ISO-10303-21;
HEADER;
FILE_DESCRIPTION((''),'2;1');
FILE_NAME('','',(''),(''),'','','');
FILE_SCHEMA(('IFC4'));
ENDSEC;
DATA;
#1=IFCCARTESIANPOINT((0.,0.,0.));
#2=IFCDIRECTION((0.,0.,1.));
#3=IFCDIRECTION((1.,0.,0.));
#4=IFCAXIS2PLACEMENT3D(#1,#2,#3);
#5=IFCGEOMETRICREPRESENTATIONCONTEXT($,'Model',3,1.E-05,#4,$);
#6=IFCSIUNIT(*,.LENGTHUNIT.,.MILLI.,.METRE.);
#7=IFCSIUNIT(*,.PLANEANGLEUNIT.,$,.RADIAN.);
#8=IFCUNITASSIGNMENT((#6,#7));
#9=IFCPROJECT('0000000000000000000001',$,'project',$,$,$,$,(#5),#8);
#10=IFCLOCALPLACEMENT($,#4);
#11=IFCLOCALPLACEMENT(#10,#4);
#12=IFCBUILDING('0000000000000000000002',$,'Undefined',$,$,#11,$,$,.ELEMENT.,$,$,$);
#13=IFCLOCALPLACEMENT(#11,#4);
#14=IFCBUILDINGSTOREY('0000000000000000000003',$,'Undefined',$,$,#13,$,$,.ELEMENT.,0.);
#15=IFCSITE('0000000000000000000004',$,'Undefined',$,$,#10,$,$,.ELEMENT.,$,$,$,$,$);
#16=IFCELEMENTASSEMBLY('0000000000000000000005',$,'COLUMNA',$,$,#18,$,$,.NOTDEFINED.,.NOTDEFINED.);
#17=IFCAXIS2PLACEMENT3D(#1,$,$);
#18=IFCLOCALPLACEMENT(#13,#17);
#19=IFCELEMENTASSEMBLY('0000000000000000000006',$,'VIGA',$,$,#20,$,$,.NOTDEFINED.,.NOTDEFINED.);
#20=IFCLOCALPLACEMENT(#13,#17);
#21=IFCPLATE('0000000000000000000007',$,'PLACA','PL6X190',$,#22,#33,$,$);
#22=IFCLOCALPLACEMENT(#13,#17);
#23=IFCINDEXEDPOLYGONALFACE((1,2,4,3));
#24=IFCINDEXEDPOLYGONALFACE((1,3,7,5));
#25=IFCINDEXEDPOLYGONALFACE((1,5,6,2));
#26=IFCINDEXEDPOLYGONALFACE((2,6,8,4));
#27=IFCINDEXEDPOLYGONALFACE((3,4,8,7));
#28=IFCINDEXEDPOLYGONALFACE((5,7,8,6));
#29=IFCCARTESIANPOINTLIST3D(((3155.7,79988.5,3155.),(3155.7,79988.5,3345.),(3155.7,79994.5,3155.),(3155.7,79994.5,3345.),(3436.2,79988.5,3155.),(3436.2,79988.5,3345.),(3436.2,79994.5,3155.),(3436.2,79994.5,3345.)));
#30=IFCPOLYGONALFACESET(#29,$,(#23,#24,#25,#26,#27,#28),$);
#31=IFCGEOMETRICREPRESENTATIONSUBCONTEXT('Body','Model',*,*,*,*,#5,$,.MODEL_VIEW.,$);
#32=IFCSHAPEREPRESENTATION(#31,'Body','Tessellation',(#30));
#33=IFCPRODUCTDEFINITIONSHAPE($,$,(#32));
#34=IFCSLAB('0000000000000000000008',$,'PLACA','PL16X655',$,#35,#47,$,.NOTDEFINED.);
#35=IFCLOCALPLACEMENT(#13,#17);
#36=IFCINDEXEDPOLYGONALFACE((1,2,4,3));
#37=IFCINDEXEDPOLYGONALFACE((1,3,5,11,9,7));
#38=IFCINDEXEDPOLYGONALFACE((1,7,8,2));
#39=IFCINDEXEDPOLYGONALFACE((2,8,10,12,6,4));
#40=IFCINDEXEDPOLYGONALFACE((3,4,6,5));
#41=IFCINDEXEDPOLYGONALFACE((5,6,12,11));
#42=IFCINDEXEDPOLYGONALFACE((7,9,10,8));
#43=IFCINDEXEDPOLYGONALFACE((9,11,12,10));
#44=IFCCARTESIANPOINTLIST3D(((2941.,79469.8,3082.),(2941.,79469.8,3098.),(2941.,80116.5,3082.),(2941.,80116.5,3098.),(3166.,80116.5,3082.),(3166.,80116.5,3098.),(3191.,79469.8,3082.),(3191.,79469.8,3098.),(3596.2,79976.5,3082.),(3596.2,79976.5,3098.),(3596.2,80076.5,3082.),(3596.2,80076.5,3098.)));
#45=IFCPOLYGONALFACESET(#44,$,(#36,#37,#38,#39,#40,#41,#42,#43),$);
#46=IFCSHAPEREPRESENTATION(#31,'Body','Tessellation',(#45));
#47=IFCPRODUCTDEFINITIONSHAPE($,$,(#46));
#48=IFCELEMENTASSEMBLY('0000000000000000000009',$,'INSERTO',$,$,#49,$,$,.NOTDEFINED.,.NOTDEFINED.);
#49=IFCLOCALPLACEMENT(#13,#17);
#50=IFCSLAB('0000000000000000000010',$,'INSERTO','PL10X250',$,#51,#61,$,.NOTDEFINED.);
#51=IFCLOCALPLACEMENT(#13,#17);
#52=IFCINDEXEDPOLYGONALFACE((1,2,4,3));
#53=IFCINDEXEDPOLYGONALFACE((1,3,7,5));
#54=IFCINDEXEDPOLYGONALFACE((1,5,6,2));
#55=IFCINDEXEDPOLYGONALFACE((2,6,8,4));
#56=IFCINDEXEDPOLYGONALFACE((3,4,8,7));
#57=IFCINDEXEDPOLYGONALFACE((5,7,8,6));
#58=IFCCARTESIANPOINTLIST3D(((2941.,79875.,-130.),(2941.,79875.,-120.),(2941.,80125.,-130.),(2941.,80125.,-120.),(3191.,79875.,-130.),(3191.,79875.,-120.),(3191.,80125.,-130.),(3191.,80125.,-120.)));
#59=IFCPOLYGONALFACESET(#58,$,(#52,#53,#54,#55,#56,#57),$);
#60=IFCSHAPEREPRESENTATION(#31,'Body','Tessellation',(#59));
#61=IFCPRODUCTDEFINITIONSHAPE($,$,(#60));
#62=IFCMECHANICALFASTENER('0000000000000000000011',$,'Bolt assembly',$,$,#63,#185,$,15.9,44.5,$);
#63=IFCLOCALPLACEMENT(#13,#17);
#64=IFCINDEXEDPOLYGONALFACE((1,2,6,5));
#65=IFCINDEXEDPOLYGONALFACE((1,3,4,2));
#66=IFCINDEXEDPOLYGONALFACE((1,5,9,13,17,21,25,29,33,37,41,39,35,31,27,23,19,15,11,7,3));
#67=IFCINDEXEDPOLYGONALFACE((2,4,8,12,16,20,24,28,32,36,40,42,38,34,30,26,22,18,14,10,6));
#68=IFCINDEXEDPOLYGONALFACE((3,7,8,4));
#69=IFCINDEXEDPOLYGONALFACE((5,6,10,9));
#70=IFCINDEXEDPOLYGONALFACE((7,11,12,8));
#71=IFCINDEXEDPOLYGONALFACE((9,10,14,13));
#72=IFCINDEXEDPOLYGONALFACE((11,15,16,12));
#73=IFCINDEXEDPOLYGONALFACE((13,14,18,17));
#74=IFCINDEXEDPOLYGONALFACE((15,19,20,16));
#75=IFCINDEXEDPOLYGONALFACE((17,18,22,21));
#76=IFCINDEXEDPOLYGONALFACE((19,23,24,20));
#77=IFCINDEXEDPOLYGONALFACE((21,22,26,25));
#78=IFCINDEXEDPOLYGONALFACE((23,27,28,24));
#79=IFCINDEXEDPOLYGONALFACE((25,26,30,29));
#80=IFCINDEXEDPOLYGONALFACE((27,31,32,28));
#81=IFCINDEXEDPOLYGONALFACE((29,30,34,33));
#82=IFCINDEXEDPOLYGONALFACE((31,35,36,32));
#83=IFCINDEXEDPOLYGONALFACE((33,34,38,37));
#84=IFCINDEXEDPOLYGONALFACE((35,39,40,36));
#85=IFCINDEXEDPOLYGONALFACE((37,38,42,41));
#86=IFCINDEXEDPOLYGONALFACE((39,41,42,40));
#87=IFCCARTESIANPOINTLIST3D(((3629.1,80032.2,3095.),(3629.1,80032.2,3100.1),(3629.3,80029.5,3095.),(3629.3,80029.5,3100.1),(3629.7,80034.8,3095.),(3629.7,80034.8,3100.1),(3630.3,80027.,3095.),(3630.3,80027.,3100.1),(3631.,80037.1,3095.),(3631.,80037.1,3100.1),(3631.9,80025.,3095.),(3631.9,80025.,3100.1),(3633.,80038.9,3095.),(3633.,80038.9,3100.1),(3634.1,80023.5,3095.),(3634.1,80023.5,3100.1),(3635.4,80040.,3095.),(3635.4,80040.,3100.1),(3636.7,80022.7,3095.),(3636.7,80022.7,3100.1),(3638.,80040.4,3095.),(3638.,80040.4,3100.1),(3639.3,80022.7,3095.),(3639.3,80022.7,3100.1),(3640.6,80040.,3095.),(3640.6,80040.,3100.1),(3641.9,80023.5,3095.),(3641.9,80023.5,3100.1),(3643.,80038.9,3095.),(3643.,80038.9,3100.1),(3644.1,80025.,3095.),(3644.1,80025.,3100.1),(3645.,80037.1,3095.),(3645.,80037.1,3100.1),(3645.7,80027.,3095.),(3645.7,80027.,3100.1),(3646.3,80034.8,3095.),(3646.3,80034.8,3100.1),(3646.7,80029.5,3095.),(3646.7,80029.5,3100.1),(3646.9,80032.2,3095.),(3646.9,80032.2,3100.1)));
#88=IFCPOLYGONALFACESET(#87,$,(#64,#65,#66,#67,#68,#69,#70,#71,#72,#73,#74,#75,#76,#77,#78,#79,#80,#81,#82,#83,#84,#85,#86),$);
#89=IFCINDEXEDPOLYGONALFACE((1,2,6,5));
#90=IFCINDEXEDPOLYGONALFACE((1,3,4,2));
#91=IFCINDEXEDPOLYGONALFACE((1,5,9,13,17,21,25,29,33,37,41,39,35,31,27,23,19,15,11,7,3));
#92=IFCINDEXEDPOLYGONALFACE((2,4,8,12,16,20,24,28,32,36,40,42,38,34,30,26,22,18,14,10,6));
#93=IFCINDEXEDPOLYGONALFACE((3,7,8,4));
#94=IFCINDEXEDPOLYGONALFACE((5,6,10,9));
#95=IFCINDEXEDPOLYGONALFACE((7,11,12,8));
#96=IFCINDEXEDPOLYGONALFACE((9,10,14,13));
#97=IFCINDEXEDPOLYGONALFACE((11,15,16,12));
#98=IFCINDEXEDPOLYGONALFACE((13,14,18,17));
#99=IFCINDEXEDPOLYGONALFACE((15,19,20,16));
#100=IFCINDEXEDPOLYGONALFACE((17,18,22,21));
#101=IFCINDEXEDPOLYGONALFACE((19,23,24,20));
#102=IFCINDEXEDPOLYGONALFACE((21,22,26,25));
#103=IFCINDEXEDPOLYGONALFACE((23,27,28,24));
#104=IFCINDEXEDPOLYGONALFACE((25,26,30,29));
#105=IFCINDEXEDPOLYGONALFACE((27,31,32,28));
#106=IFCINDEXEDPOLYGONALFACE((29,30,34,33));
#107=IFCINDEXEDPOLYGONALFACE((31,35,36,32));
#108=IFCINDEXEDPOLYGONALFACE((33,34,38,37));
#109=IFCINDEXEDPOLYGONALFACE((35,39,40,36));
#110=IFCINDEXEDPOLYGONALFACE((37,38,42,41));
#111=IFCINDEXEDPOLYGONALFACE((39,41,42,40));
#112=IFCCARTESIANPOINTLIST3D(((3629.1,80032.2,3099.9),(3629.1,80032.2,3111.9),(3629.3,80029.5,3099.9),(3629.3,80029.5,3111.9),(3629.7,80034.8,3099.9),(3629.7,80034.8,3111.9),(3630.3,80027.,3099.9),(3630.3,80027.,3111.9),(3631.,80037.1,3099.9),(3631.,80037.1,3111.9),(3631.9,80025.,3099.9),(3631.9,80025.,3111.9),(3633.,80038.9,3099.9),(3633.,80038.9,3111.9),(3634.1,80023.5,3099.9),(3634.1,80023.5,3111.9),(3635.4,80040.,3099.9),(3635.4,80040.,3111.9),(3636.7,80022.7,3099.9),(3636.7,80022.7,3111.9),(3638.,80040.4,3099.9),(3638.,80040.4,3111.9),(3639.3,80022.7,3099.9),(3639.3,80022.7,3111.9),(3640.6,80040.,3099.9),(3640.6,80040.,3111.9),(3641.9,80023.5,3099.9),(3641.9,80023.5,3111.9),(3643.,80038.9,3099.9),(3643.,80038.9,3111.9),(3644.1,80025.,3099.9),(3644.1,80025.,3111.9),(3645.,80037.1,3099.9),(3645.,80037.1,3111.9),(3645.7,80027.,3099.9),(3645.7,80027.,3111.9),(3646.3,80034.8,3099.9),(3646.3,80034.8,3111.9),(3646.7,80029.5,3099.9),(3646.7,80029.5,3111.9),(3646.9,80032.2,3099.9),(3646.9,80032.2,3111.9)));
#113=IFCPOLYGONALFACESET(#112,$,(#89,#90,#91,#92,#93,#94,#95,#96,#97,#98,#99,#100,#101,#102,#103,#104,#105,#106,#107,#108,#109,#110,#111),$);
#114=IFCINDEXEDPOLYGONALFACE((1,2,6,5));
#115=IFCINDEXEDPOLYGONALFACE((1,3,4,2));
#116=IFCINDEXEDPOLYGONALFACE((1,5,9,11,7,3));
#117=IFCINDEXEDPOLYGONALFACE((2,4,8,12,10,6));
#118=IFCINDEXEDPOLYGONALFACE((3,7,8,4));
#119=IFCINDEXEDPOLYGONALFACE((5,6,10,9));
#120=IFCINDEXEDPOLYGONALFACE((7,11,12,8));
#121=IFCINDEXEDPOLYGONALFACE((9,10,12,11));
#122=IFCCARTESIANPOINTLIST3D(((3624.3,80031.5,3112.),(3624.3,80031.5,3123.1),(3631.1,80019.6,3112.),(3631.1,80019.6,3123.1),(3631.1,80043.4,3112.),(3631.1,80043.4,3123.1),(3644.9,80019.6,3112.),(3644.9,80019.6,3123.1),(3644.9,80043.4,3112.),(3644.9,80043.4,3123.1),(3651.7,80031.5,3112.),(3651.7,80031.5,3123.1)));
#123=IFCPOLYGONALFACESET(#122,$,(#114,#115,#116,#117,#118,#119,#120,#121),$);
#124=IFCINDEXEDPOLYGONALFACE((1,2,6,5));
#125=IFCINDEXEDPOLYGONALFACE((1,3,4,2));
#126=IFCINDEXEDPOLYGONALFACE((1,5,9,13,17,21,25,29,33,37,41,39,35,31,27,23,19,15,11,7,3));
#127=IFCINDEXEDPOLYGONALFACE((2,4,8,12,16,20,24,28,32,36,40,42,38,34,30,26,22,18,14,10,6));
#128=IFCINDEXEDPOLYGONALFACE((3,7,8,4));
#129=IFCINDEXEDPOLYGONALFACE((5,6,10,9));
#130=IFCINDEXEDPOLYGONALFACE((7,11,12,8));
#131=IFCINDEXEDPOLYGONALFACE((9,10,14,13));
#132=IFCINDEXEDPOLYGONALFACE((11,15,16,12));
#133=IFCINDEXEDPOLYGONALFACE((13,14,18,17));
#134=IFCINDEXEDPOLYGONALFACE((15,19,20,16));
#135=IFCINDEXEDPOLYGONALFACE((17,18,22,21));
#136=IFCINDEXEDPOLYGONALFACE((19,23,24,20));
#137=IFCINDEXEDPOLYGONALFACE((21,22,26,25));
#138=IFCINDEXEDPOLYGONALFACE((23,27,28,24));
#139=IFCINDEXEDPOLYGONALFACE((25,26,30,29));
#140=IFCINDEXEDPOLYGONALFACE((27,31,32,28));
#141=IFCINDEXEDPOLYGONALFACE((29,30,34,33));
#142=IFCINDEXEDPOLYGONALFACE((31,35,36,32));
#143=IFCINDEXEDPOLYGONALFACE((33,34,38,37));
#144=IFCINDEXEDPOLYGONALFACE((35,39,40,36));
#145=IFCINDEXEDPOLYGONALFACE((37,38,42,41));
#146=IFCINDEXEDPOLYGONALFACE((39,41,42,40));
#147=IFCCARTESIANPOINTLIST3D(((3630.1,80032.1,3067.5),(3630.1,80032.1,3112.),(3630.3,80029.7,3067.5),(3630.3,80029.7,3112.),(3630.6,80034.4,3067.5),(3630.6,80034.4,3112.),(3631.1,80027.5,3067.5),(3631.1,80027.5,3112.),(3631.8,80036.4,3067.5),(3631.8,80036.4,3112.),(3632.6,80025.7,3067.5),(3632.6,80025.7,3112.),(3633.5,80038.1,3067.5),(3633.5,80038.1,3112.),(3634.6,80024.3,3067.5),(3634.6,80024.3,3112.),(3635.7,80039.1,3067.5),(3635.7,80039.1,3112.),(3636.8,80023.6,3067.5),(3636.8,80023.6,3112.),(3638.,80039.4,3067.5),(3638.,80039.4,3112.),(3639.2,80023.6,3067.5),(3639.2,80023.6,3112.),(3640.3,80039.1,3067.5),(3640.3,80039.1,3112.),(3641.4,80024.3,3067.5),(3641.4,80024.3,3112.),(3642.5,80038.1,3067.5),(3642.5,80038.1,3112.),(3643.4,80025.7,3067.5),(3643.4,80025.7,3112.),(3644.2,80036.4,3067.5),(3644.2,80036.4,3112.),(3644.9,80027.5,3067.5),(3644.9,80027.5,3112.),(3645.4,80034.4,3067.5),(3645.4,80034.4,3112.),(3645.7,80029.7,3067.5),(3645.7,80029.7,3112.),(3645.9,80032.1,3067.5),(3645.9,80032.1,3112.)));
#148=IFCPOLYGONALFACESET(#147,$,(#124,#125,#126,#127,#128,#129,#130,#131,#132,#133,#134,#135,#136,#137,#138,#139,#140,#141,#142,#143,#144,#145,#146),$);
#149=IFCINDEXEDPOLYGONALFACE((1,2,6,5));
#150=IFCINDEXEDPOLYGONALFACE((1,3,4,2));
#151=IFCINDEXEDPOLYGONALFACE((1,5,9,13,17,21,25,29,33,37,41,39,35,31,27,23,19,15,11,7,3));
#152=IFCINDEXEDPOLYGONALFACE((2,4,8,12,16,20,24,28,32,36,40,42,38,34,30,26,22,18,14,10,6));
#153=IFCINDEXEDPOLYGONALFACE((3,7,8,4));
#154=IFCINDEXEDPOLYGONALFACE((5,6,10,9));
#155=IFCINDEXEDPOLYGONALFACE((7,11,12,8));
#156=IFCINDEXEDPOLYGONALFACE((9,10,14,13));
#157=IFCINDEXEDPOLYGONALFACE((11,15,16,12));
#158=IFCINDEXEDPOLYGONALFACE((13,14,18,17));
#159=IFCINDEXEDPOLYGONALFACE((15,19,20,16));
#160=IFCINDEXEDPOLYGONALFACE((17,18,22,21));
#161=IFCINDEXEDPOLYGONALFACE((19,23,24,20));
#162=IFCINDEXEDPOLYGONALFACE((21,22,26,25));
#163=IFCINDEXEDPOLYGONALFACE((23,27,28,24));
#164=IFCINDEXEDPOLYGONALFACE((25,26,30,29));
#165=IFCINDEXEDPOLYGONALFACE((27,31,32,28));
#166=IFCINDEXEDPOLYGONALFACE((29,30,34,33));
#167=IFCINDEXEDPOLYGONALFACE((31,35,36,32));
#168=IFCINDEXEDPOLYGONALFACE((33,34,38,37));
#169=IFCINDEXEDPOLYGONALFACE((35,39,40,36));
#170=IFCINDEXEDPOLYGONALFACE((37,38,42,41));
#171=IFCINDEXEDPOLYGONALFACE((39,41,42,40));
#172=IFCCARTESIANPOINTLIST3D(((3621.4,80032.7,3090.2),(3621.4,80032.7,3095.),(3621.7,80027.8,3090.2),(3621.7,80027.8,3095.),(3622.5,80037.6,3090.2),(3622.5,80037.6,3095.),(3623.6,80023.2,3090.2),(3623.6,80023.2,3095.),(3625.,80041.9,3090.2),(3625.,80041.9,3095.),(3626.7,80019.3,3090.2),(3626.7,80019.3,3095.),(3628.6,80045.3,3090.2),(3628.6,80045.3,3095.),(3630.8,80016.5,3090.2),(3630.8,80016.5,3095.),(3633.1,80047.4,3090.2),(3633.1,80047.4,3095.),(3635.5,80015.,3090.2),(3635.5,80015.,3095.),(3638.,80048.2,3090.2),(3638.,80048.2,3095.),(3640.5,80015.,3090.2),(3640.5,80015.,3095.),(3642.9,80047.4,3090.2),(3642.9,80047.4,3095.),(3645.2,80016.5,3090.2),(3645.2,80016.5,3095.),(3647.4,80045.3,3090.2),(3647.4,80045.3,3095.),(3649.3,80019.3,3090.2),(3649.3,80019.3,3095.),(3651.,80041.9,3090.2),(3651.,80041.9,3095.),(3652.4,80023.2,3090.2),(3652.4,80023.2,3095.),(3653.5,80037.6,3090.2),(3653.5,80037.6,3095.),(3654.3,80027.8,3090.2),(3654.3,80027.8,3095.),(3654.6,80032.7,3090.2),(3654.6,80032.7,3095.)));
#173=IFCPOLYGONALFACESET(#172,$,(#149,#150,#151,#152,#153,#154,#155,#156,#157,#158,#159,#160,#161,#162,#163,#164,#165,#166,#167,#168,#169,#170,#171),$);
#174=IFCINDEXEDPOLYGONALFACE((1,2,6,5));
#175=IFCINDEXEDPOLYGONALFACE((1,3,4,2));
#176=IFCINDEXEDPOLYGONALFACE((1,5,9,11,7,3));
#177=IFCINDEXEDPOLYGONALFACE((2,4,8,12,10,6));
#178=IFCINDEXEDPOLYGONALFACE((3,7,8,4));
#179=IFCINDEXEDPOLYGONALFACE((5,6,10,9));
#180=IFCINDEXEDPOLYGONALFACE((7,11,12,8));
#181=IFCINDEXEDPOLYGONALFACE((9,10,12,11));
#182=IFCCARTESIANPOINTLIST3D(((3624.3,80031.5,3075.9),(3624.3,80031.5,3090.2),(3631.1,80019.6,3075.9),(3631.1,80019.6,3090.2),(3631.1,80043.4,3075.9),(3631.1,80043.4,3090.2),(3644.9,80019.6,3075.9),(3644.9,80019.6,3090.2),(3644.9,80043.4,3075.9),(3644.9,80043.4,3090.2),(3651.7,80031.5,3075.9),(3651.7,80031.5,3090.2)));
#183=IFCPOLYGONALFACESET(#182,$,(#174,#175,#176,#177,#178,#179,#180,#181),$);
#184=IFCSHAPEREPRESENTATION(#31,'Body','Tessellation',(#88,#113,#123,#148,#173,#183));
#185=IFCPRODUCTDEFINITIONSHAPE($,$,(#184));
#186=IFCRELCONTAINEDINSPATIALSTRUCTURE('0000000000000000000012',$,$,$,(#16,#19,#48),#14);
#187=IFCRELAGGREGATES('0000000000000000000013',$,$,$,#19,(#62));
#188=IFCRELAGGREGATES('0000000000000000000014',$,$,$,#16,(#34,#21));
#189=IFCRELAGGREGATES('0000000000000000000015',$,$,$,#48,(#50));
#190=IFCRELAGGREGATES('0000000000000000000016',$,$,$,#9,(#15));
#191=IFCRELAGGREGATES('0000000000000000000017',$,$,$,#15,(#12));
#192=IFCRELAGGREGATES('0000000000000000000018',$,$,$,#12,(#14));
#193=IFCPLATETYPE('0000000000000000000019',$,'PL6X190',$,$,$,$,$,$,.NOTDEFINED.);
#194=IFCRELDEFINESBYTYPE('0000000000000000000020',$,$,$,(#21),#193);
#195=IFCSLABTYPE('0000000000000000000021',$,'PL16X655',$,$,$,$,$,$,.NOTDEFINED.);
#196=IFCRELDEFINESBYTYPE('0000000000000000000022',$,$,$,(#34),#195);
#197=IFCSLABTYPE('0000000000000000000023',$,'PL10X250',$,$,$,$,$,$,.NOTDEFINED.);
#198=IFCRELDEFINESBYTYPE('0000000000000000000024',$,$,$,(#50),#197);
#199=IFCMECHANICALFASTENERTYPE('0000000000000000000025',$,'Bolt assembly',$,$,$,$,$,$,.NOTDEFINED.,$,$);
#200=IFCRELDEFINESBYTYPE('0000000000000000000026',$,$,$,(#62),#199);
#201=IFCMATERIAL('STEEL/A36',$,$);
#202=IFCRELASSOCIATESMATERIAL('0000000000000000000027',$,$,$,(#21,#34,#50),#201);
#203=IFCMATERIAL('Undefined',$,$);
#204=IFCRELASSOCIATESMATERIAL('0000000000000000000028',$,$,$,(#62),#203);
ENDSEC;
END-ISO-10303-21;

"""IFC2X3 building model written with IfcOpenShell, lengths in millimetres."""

from ifc_helpers import new_model, si_unit, frame, origin_with_axes, origin_2d_with_axis, place, context, subcontext, project, spatial, polyline, circle, outline, extrude, source, transform, mapped, material, type_object, element, aggregate, save


model = new_model("IFC2X3")

# Units and contexts
model_context = context("Model", 3, precision=1e-05, world=origin_with_axes())
body_context = subcontext(model_context, "Body", "Model", "MODEL_VIEW")
ifc_project = project(units=[si_unit("LENGTHUNIT", "METRE", prefix="MILLI"), si_unit("PLANEANGLEUNIT", "RADIAN")], contexts=[model_context])

# Site, building, storey
site_placement = place(None, origin_with_axes())
site = spatial("IfcSite", under=ifc_project, at=site_placement, Name="Undefined", CompositionType="ELEMENT")
building_placement = place(site_placement, origin_with_axes())
building = spatial("IfcBuilding", under=site, at=building_placement, Name="Undefined", CompositionType="ELEMENT")
storey_placement = place(building_placement, origin_with_axes())
storey = spatial("IfcBuildingStorey", under=building, at=storey_placement, Name="Undefined", CompositionType="ELEMENT", Elevation=0.0)

# Element assembly
assembly_1_placement = place(storey_placement, origin_with_axes())
assembly_1 = element("IfcElementAssembly", 1, at=assembly_1_placement, inside=storey, Name="COLUMNA", AssemblyPlace="NOTDEFINED", PredefinedType="NOTDEFINED")
ifc_material_1 = material(Name="STEEL/A36")

# Element assembly
assembly_2_placement = place(storey_placement, origin_with_axes())
assembly_2 = element("IfcElementAssembly", 2, at=assembly_2_placement, inside=storey, Name="VIGA", AssemblyPlace="NOTDEFINED", PredefinedType="NOTDEFINED")

# Plate
plate_type_1 = type_object("IfcPlateType", Name="PL6X190", PredefinedType="NOTDEFINED")
plate_1_placement = place(assembly_1_placement, frame((3436.2, 79991.5, 3250.0), z_axis=(0.0, 1.0, 0.0), x_axis=(-1.0, 0.0, 0.0)))
plate_1 = element("IfcPlate", 3, at=plate_1_placement, type_object=plate_type_1, material=ifc_material_1, Name="PLACA", Description="PL6X190", context=body_context, shape_type="SweptSolid", body=[
    extrude(outline(polyline([(0.0, -95.0), (0.0, 95.0), (280.5, 95.0), (280.5, -95.0), (0.0, -95.0)])), frame((0.0, 0.0, -3.0), z_axis=(0.0, 0.0, 1.0), x_axis=(1.0, 0.0, 0.0)), (0.0, 0.0, 1.0), 6.0),
])

# Slab
slab_type_1 = type_object("IfcSlabType", Name="PL16X655", PredefinedType="NOTDEFINED")
slab_1_placement = place(assembly_1_placement, frame((3191.0, 79469.8, 3090.0), z_axis=(0.0, 0.0, 1.0), x_axis=(0.624549, 0.780985, 0.0)))
slab_1 = element("IfcSlab", 4, at=slab_1_placement, type_object=slab_type_1, material=ifc_material_1, Name="PLACA", Description="PL16X655", PredefinedType="NOTDEFINED", context=body_context, shape_type="SweptSolid", body=[
    extrude(outline(polyline([(0.0, 0.0), (648.8, 0.0), (726.9, 62.5), (489.5, 423.4), (348.9, 599.2), (-156.1, 195.2), (0.0, 0.0)])), frame((0.0, 0.0, -8.0), z_axis=(0.0, 0.0, 1.0), x_axis=(1.0, 0.0, 0.0)), (0.0, 0.0, 1.0), 16.0),
])

# Element assembly, slab
assembly_3_placement = place(storey_placement, origin_with_axes())
assembly_3 = element("IfcElementAssembly", 5, at=assembly_3_placement, inside=storey, Name="INSERTO", AssemblyPlace="NOTDEFINED", PredefinedType="NOTDEFINED")
slab_type_2 = type_object("IfcSlabType", Name="PL10X250", PredefinedType="NOTDEFINED")
slab_2_placement = place(assembly_3_placement, frame((2941.0, 79875.0, -125.0), z_axis=(0.0, 0.0, 1.0), x_axis=(1.0, 0.0, 0.0)))
slab_2 = element("IfcSlab", 6, at=slab_2_placement, type_object=slab_type_2, material=ifc_material_1, Name="INSERTO", Description="PL10X250", PredefinedType="NOTDEFINED", context=body_context, shape_type="SweptSolid", body=[
    extrude(outline(polyline([(0.0, 0.0), (250.0, 0.0), (250.0, 250.0), (0.0, 250.0), (0.0, 0.0)])), frame((0.0, 0.0, -5.0), z_axis=(0.0, 0.0, 1.0), x_axis=(1.0, 0.0, 0.0)), (0.0, 0.0, 1.0), 10.0),
])

# Mechanical fastener
ifc_material_2 = material(Name="Undefined")
mechanical_fastener_type = type_object("IfcMechanicalFastenerType", Name="Bolt assembly")
shared_shape_1 = source(origin_with_axes(), body_context, "Body", "SweptSolid", [
    extrude(circle(Radius=8.9, at=origin_2d_with_axis()), frame((0.0, -0.1, 0.0), z_axis=(0.0, 1.0, 0.0), x_axis=(1.0, 0.0, 0.0)), (0.0, 0.0, 1.0), 5.1),
    extrude(circle(Radius=8.9, at=origin_2d_with_axis()), frame((0.0, -11.9, 0.0), z_axis=(0.0, 1.0, 0.0), x_axis=(1.0, 0.0, 0.0)), (0.0, 0.0, 1.0), 12.0),
    extrude(outline(polyline([(11.9, -6.9), (11.9, 6.9), (0.0, 13.7), (-11.9, 6.9), (-11.9, -6.9), (0.0, -13.7), (11.9, -6.9)])), frame((0.0, -23.1, 0.0), z_axis=(0.0, 1.0, 0.0), x_axis=(1.0, 0.0, 0.0)), (0.0, 0.0, 1.0), 11.1),
    extrude(circle(Radius=7.9, at=origin_2d_with_axis()), frame((0.0, -12.0, 0.0), z_axis=(0.0, 1.0, 0.0), x_axis=(1.0, 0.0, 0.0)), (0.0, 0.0, 1.0), 44.5),
    extrude(circle(Radius=16.7, at=origin_2d_with_axis()), frame((0.0, 5.0, 0.0), z_axis=(0.0, 1.0, 0.0), x_axis=(1.0, 0.0, 0.0)), (0.0, 0.0, 1.0), 4.8),
    extrude(outline(polyline([(11.9, -6.9), (11.9, 6.9), (0.0, 13.7), (-11.9, 6.9), (-11.9, -6.9), (0.0, -13.7), (11.9, -6.9)])), frame((0.0, 9.8, 0.0), z_axis=(0.0, 1.0, 0.0), x_axis=(1.0, 0.0, 0.0)), (0.0, 0.0, 1.0), 14.3),
])
mechanical_fastener_1_placement = place(assembly_2_placement, frame((3638.0, 80031.5, 3100.0), z_axis=(-1.0, -0.000006, 0.0), x_axis=(-0.000006, 1.0, 0.0)))
mechanical_fastener_1 = element("IfcMechanicalFastener", 7, at=mechanical_fastener_1_placement, type_object=mechanical_fastener_type, material=ifc_material_2, Name="Bolt assembly", NominalDiameter=15.9, NominalLength=44.5, context=body_context, shape_type="MappedRepresentation", body=[
    mapped(shared_shape_1, transform((0.0, 0.0, 0.0))),
])
aggregate(assembly_2, [mechanical_fastener_1])

aggregate(assembly_1, [slab_1, plate_1])
aggregate(assembly_3, [slab_2])

save(model, "model.ifc")
